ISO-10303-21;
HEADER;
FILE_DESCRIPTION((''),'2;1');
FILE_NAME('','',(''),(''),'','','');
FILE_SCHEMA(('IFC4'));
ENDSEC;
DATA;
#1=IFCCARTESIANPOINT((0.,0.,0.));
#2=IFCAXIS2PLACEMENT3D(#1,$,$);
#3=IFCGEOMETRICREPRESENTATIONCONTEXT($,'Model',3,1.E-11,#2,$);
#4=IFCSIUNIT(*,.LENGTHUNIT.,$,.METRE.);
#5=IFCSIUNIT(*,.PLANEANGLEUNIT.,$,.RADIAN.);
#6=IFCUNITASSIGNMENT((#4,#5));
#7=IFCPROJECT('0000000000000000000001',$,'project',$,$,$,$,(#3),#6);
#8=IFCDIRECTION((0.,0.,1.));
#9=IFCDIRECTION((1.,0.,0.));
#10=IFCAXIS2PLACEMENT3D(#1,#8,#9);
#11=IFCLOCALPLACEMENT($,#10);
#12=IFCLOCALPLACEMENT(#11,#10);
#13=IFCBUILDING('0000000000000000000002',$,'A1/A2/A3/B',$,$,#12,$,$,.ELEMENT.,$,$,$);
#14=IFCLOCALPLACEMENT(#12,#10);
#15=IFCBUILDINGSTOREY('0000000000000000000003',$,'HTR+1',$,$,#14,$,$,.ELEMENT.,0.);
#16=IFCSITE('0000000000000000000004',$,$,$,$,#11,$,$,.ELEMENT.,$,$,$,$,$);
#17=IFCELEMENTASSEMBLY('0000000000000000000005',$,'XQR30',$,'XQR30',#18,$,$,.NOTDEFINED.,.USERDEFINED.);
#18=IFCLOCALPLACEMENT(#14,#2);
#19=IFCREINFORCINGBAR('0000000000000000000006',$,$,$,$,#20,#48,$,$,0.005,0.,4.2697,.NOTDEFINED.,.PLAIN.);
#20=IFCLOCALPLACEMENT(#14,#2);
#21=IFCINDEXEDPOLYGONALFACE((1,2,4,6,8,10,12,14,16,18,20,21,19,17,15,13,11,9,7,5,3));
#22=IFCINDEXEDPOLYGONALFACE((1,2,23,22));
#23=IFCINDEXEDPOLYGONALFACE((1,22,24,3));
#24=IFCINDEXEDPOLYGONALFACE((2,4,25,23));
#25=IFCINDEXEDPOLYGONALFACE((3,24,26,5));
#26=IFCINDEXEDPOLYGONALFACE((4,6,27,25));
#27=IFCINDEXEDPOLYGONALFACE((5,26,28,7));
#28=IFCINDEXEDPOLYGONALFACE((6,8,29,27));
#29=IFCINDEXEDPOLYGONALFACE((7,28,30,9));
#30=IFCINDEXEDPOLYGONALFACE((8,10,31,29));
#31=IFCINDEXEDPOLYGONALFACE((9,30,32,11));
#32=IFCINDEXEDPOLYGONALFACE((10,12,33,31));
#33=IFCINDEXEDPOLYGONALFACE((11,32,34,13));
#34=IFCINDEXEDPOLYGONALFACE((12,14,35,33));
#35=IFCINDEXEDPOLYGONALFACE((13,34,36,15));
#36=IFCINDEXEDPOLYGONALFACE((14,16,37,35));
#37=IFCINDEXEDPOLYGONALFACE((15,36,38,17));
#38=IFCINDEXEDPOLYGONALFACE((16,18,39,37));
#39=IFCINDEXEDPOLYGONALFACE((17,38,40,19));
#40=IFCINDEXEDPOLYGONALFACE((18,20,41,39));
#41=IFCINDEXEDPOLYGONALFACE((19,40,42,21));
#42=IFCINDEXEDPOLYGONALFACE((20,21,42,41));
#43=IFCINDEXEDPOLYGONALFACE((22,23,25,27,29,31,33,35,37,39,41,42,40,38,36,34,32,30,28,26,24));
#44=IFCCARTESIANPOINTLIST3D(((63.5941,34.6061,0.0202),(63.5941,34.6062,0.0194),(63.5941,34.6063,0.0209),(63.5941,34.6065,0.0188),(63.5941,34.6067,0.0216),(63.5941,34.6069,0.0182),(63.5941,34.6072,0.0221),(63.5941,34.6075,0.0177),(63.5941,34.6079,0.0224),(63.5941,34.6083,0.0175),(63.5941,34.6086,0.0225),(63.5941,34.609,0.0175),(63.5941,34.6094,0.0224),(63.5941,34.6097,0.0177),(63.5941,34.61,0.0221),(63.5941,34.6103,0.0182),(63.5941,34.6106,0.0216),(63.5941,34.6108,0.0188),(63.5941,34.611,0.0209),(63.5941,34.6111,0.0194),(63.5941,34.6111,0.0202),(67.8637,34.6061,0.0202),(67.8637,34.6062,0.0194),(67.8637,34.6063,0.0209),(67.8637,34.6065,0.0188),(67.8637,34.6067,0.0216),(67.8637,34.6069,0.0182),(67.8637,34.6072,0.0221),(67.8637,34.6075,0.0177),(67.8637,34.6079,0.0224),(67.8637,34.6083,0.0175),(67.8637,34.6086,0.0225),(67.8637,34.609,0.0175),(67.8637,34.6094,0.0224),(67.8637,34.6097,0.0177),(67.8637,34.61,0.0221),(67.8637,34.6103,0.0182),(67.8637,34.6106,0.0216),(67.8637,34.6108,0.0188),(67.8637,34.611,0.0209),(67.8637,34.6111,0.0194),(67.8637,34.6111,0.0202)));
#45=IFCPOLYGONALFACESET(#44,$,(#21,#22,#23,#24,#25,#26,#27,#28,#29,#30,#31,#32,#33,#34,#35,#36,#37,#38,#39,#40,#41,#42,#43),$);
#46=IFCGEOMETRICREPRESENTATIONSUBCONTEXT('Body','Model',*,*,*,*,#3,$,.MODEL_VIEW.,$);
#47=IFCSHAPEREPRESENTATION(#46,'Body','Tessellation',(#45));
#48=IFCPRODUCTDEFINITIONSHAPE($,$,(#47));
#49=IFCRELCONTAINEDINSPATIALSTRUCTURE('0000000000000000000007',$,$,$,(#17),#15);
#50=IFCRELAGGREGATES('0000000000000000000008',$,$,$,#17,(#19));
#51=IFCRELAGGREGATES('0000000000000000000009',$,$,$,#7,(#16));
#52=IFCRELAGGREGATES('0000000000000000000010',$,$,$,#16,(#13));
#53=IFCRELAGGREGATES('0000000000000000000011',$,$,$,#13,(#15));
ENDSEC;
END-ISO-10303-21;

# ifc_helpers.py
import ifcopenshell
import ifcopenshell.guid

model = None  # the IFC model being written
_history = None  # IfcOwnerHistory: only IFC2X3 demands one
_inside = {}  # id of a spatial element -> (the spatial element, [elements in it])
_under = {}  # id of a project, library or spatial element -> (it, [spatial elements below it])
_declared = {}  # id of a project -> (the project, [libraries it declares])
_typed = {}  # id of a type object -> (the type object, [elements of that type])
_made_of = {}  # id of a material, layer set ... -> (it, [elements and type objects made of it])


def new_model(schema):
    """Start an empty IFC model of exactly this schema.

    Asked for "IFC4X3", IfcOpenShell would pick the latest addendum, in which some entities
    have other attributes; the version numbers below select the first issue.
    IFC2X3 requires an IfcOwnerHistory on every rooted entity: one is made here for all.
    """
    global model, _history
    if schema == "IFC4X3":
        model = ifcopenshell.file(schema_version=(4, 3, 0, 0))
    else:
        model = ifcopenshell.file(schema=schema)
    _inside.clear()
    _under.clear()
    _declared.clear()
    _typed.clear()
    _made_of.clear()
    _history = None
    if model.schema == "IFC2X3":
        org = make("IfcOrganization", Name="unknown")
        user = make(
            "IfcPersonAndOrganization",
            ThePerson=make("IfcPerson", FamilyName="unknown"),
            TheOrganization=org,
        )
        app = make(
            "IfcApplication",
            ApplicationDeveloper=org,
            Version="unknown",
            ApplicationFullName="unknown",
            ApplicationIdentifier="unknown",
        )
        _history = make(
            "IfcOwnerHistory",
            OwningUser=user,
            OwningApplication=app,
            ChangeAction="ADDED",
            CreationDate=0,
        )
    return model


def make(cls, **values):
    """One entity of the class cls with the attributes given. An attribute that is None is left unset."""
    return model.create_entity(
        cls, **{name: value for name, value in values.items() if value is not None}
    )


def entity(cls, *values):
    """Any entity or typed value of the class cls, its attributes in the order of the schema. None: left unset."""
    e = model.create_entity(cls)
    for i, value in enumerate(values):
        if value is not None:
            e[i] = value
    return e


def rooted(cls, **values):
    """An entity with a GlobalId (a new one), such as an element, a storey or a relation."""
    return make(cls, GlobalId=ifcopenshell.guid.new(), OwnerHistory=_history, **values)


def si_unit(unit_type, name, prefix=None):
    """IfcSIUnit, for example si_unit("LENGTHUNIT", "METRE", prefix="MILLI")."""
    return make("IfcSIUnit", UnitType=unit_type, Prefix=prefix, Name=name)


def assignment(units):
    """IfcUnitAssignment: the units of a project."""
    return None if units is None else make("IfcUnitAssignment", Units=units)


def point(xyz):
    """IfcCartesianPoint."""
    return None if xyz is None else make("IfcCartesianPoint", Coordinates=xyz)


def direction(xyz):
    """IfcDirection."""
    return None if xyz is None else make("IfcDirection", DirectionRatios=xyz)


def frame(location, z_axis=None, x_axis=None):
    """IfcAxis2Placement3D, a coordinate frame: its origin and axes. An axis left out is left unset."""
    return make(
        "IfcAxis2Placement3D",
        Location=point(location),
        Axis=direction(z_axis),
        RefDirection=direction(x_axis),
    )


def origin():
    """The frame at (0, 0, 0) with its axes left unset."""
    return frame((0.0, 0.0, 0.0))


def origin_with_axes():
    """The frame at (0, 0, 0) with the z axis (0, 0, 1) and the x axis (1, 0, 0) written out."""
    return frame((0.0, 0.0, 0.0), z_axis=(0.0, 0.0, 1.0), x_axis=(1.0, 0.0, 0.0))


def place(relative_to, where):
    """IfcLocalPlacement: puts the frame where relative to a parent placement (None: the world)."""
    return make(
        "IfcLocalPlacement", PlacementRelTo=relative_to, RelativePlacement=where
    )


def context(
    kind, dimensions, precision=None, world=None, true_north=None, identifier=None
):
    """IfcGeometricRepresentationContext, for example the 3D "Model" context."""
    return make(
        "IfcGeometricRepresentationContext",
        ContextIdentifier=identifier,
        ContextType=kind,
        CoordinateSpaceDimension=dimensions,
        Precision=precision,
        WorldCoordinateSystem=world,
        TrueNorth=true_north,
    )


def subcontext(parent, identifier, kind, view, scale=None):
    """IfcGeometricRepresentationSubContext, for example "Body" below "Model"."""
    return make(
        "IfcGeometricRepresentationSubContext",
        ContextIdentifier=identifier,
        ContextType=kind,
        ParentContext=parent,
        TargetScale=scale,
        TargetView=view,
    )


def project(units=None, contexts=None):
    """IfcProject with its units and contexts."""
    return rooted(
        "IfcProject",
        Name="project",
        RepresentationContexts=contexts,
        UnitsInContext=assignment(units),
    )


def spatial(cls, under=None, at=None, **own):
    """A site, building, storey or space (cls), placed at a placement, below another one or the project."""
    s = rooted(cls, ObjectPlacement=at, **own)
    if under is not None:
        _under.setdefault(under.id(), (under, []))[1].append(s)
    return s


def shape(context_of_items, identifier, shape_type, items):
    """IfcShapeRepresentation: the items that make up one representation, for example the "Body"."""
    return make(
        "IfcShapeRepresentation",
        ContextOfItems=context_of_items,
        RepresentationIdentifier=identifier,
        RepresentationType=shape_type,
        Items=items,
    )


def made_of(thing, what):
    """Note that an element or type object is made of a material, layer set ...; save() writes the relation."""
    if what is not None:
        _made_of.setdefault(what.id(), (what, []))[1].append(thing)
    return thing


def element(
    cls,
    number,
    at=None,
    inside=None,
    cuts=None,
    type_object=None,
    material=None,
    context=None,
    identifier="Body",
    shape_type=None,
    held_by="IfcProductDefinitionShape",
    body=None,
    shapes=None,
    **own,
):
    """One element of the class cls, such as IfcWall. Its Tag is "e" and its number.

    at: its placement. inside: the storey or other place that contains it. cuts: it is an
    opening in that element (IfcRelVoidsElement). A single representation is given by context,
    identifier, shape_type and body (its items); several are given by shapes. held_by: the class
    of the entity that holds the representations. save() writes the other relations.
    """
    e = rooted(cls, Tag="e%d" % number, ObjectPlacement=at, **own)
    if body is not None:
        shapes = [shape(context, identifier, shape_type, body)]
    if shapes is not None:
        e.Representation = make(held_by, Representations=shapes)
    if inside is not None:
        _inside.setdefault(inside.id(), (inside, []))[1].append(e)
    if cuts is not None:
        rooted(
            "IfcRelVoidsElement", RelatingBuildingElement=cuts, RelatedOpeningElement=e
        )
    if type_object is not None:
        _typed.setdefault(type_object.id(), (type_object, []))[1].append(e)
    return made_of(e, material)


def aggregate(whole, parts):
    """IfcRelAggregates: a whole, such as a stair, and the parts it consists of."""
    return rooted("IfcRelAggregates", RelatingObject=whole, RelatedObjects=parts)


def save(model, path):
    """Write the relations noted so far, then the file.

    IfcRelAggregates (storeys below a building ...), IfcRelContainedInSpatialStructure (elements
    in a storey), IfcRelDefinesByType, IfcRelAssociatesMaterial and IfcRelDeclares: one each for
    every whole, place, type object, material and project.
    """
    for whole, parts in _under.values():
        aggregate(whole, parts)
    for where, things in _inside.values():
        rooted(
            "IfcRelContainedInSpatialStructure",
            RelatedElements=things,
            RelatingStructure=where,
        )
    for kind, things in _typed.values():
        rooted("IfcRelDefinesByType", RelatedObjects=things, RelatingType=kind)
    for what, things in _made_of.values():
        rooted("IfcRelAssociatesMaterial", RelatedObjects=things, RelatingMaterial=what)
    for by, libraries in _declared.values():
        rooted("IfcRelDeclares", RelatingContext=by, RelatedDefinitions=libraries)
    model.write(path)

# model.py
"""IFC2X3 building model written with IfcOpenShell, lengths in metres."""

from ifc_helpers import new_model, entity, si_unit, origin, origin_with_axes, place, context, subcontext, project, spatial, shape, element, aggregate, save


model = new_model("IFC2X3")

# Units and contexts
model_context = context("Model", 3, precision=1e-11, world=origin())
body_context = subcontext(model_context, "Body", "Model", "MODEL_VIEW")
ifc_project = project(units=[si_unit("LENGTHUNIT", "METRE"), si_unit("PLANEANGLEUNIT", "RADIAN")], contexts=[model_context])

# Site, building, storey
site_placement = place(None, origin_with_axes())
site = spatial("IfcSite", under=ifc_project, at=site_placement, CompositionType="ELEMENT")
building_placement = place(site_placement, origin_with_axes())
building = spatial("IfcBuilding", under=site, at=building_placement, Name="A1/A2/A3/B", CompositionType="ELEMENT")
storey_placement = place(building_placement, origin_with_axes())
storey = spatial("IfcBuildingStorey", under=building, at=storey_placement, Name="HTR+1", CompositionType="ELEMENT", Elevation=0.0)

# Element assembly, reinforcing bar
assembly_1_placement = place(storey_placement, origin_with_axes())
assembly_1 = element("IfcElementAssembly", 1, at=assembly_1_placement, inside=storey, Name="XQR30", ObjectType="XQR30", AssemblyPlace="NOTDEFINED", PredefinedType="USERDEFINED")
reinforcing_bar_1_placement = place(assembly_1_placement, origin_with_axes())
reinforcing_bar_1 = element("IfcReinforcingBar", 2, at=reinforcing_bar_1_placement, BarLength=4.2697, BarRole="NOTDEFINED", BarSurface="PLAIN", CrossSectionArea=0.0, NominalDiameter=0.005, shapes=[
    shape(body_context, "Body", "AdvancedSweptSolid", [entity("IfcSweptDiskSolid", entity("IfcPolyline", [entity("IfcCartesianPoint", [63.5941, 34.6086, 0.02]), entity("IfcCartesianPoint", [67.8637, 34.6086, 0.02])]), 0.0025, None, 0.0, 4.2697)]),
    shape(body_context, "Body", "AdvancedSweptSolid", [entity("IfcSweptDiskSolid", entity("IfcPolyline", [entity("IfcCartesianPoint", [63.5941, 34.6086, 0.02]), entity("IfcCartesianPoint", [67.8637, 34.6086, 0.02])]), 0.0025, None, 0.0, 4.2697)]),
])
aggregate(assembly_1, [reinforcing_bar_1])

save(model, "model.ifc")
